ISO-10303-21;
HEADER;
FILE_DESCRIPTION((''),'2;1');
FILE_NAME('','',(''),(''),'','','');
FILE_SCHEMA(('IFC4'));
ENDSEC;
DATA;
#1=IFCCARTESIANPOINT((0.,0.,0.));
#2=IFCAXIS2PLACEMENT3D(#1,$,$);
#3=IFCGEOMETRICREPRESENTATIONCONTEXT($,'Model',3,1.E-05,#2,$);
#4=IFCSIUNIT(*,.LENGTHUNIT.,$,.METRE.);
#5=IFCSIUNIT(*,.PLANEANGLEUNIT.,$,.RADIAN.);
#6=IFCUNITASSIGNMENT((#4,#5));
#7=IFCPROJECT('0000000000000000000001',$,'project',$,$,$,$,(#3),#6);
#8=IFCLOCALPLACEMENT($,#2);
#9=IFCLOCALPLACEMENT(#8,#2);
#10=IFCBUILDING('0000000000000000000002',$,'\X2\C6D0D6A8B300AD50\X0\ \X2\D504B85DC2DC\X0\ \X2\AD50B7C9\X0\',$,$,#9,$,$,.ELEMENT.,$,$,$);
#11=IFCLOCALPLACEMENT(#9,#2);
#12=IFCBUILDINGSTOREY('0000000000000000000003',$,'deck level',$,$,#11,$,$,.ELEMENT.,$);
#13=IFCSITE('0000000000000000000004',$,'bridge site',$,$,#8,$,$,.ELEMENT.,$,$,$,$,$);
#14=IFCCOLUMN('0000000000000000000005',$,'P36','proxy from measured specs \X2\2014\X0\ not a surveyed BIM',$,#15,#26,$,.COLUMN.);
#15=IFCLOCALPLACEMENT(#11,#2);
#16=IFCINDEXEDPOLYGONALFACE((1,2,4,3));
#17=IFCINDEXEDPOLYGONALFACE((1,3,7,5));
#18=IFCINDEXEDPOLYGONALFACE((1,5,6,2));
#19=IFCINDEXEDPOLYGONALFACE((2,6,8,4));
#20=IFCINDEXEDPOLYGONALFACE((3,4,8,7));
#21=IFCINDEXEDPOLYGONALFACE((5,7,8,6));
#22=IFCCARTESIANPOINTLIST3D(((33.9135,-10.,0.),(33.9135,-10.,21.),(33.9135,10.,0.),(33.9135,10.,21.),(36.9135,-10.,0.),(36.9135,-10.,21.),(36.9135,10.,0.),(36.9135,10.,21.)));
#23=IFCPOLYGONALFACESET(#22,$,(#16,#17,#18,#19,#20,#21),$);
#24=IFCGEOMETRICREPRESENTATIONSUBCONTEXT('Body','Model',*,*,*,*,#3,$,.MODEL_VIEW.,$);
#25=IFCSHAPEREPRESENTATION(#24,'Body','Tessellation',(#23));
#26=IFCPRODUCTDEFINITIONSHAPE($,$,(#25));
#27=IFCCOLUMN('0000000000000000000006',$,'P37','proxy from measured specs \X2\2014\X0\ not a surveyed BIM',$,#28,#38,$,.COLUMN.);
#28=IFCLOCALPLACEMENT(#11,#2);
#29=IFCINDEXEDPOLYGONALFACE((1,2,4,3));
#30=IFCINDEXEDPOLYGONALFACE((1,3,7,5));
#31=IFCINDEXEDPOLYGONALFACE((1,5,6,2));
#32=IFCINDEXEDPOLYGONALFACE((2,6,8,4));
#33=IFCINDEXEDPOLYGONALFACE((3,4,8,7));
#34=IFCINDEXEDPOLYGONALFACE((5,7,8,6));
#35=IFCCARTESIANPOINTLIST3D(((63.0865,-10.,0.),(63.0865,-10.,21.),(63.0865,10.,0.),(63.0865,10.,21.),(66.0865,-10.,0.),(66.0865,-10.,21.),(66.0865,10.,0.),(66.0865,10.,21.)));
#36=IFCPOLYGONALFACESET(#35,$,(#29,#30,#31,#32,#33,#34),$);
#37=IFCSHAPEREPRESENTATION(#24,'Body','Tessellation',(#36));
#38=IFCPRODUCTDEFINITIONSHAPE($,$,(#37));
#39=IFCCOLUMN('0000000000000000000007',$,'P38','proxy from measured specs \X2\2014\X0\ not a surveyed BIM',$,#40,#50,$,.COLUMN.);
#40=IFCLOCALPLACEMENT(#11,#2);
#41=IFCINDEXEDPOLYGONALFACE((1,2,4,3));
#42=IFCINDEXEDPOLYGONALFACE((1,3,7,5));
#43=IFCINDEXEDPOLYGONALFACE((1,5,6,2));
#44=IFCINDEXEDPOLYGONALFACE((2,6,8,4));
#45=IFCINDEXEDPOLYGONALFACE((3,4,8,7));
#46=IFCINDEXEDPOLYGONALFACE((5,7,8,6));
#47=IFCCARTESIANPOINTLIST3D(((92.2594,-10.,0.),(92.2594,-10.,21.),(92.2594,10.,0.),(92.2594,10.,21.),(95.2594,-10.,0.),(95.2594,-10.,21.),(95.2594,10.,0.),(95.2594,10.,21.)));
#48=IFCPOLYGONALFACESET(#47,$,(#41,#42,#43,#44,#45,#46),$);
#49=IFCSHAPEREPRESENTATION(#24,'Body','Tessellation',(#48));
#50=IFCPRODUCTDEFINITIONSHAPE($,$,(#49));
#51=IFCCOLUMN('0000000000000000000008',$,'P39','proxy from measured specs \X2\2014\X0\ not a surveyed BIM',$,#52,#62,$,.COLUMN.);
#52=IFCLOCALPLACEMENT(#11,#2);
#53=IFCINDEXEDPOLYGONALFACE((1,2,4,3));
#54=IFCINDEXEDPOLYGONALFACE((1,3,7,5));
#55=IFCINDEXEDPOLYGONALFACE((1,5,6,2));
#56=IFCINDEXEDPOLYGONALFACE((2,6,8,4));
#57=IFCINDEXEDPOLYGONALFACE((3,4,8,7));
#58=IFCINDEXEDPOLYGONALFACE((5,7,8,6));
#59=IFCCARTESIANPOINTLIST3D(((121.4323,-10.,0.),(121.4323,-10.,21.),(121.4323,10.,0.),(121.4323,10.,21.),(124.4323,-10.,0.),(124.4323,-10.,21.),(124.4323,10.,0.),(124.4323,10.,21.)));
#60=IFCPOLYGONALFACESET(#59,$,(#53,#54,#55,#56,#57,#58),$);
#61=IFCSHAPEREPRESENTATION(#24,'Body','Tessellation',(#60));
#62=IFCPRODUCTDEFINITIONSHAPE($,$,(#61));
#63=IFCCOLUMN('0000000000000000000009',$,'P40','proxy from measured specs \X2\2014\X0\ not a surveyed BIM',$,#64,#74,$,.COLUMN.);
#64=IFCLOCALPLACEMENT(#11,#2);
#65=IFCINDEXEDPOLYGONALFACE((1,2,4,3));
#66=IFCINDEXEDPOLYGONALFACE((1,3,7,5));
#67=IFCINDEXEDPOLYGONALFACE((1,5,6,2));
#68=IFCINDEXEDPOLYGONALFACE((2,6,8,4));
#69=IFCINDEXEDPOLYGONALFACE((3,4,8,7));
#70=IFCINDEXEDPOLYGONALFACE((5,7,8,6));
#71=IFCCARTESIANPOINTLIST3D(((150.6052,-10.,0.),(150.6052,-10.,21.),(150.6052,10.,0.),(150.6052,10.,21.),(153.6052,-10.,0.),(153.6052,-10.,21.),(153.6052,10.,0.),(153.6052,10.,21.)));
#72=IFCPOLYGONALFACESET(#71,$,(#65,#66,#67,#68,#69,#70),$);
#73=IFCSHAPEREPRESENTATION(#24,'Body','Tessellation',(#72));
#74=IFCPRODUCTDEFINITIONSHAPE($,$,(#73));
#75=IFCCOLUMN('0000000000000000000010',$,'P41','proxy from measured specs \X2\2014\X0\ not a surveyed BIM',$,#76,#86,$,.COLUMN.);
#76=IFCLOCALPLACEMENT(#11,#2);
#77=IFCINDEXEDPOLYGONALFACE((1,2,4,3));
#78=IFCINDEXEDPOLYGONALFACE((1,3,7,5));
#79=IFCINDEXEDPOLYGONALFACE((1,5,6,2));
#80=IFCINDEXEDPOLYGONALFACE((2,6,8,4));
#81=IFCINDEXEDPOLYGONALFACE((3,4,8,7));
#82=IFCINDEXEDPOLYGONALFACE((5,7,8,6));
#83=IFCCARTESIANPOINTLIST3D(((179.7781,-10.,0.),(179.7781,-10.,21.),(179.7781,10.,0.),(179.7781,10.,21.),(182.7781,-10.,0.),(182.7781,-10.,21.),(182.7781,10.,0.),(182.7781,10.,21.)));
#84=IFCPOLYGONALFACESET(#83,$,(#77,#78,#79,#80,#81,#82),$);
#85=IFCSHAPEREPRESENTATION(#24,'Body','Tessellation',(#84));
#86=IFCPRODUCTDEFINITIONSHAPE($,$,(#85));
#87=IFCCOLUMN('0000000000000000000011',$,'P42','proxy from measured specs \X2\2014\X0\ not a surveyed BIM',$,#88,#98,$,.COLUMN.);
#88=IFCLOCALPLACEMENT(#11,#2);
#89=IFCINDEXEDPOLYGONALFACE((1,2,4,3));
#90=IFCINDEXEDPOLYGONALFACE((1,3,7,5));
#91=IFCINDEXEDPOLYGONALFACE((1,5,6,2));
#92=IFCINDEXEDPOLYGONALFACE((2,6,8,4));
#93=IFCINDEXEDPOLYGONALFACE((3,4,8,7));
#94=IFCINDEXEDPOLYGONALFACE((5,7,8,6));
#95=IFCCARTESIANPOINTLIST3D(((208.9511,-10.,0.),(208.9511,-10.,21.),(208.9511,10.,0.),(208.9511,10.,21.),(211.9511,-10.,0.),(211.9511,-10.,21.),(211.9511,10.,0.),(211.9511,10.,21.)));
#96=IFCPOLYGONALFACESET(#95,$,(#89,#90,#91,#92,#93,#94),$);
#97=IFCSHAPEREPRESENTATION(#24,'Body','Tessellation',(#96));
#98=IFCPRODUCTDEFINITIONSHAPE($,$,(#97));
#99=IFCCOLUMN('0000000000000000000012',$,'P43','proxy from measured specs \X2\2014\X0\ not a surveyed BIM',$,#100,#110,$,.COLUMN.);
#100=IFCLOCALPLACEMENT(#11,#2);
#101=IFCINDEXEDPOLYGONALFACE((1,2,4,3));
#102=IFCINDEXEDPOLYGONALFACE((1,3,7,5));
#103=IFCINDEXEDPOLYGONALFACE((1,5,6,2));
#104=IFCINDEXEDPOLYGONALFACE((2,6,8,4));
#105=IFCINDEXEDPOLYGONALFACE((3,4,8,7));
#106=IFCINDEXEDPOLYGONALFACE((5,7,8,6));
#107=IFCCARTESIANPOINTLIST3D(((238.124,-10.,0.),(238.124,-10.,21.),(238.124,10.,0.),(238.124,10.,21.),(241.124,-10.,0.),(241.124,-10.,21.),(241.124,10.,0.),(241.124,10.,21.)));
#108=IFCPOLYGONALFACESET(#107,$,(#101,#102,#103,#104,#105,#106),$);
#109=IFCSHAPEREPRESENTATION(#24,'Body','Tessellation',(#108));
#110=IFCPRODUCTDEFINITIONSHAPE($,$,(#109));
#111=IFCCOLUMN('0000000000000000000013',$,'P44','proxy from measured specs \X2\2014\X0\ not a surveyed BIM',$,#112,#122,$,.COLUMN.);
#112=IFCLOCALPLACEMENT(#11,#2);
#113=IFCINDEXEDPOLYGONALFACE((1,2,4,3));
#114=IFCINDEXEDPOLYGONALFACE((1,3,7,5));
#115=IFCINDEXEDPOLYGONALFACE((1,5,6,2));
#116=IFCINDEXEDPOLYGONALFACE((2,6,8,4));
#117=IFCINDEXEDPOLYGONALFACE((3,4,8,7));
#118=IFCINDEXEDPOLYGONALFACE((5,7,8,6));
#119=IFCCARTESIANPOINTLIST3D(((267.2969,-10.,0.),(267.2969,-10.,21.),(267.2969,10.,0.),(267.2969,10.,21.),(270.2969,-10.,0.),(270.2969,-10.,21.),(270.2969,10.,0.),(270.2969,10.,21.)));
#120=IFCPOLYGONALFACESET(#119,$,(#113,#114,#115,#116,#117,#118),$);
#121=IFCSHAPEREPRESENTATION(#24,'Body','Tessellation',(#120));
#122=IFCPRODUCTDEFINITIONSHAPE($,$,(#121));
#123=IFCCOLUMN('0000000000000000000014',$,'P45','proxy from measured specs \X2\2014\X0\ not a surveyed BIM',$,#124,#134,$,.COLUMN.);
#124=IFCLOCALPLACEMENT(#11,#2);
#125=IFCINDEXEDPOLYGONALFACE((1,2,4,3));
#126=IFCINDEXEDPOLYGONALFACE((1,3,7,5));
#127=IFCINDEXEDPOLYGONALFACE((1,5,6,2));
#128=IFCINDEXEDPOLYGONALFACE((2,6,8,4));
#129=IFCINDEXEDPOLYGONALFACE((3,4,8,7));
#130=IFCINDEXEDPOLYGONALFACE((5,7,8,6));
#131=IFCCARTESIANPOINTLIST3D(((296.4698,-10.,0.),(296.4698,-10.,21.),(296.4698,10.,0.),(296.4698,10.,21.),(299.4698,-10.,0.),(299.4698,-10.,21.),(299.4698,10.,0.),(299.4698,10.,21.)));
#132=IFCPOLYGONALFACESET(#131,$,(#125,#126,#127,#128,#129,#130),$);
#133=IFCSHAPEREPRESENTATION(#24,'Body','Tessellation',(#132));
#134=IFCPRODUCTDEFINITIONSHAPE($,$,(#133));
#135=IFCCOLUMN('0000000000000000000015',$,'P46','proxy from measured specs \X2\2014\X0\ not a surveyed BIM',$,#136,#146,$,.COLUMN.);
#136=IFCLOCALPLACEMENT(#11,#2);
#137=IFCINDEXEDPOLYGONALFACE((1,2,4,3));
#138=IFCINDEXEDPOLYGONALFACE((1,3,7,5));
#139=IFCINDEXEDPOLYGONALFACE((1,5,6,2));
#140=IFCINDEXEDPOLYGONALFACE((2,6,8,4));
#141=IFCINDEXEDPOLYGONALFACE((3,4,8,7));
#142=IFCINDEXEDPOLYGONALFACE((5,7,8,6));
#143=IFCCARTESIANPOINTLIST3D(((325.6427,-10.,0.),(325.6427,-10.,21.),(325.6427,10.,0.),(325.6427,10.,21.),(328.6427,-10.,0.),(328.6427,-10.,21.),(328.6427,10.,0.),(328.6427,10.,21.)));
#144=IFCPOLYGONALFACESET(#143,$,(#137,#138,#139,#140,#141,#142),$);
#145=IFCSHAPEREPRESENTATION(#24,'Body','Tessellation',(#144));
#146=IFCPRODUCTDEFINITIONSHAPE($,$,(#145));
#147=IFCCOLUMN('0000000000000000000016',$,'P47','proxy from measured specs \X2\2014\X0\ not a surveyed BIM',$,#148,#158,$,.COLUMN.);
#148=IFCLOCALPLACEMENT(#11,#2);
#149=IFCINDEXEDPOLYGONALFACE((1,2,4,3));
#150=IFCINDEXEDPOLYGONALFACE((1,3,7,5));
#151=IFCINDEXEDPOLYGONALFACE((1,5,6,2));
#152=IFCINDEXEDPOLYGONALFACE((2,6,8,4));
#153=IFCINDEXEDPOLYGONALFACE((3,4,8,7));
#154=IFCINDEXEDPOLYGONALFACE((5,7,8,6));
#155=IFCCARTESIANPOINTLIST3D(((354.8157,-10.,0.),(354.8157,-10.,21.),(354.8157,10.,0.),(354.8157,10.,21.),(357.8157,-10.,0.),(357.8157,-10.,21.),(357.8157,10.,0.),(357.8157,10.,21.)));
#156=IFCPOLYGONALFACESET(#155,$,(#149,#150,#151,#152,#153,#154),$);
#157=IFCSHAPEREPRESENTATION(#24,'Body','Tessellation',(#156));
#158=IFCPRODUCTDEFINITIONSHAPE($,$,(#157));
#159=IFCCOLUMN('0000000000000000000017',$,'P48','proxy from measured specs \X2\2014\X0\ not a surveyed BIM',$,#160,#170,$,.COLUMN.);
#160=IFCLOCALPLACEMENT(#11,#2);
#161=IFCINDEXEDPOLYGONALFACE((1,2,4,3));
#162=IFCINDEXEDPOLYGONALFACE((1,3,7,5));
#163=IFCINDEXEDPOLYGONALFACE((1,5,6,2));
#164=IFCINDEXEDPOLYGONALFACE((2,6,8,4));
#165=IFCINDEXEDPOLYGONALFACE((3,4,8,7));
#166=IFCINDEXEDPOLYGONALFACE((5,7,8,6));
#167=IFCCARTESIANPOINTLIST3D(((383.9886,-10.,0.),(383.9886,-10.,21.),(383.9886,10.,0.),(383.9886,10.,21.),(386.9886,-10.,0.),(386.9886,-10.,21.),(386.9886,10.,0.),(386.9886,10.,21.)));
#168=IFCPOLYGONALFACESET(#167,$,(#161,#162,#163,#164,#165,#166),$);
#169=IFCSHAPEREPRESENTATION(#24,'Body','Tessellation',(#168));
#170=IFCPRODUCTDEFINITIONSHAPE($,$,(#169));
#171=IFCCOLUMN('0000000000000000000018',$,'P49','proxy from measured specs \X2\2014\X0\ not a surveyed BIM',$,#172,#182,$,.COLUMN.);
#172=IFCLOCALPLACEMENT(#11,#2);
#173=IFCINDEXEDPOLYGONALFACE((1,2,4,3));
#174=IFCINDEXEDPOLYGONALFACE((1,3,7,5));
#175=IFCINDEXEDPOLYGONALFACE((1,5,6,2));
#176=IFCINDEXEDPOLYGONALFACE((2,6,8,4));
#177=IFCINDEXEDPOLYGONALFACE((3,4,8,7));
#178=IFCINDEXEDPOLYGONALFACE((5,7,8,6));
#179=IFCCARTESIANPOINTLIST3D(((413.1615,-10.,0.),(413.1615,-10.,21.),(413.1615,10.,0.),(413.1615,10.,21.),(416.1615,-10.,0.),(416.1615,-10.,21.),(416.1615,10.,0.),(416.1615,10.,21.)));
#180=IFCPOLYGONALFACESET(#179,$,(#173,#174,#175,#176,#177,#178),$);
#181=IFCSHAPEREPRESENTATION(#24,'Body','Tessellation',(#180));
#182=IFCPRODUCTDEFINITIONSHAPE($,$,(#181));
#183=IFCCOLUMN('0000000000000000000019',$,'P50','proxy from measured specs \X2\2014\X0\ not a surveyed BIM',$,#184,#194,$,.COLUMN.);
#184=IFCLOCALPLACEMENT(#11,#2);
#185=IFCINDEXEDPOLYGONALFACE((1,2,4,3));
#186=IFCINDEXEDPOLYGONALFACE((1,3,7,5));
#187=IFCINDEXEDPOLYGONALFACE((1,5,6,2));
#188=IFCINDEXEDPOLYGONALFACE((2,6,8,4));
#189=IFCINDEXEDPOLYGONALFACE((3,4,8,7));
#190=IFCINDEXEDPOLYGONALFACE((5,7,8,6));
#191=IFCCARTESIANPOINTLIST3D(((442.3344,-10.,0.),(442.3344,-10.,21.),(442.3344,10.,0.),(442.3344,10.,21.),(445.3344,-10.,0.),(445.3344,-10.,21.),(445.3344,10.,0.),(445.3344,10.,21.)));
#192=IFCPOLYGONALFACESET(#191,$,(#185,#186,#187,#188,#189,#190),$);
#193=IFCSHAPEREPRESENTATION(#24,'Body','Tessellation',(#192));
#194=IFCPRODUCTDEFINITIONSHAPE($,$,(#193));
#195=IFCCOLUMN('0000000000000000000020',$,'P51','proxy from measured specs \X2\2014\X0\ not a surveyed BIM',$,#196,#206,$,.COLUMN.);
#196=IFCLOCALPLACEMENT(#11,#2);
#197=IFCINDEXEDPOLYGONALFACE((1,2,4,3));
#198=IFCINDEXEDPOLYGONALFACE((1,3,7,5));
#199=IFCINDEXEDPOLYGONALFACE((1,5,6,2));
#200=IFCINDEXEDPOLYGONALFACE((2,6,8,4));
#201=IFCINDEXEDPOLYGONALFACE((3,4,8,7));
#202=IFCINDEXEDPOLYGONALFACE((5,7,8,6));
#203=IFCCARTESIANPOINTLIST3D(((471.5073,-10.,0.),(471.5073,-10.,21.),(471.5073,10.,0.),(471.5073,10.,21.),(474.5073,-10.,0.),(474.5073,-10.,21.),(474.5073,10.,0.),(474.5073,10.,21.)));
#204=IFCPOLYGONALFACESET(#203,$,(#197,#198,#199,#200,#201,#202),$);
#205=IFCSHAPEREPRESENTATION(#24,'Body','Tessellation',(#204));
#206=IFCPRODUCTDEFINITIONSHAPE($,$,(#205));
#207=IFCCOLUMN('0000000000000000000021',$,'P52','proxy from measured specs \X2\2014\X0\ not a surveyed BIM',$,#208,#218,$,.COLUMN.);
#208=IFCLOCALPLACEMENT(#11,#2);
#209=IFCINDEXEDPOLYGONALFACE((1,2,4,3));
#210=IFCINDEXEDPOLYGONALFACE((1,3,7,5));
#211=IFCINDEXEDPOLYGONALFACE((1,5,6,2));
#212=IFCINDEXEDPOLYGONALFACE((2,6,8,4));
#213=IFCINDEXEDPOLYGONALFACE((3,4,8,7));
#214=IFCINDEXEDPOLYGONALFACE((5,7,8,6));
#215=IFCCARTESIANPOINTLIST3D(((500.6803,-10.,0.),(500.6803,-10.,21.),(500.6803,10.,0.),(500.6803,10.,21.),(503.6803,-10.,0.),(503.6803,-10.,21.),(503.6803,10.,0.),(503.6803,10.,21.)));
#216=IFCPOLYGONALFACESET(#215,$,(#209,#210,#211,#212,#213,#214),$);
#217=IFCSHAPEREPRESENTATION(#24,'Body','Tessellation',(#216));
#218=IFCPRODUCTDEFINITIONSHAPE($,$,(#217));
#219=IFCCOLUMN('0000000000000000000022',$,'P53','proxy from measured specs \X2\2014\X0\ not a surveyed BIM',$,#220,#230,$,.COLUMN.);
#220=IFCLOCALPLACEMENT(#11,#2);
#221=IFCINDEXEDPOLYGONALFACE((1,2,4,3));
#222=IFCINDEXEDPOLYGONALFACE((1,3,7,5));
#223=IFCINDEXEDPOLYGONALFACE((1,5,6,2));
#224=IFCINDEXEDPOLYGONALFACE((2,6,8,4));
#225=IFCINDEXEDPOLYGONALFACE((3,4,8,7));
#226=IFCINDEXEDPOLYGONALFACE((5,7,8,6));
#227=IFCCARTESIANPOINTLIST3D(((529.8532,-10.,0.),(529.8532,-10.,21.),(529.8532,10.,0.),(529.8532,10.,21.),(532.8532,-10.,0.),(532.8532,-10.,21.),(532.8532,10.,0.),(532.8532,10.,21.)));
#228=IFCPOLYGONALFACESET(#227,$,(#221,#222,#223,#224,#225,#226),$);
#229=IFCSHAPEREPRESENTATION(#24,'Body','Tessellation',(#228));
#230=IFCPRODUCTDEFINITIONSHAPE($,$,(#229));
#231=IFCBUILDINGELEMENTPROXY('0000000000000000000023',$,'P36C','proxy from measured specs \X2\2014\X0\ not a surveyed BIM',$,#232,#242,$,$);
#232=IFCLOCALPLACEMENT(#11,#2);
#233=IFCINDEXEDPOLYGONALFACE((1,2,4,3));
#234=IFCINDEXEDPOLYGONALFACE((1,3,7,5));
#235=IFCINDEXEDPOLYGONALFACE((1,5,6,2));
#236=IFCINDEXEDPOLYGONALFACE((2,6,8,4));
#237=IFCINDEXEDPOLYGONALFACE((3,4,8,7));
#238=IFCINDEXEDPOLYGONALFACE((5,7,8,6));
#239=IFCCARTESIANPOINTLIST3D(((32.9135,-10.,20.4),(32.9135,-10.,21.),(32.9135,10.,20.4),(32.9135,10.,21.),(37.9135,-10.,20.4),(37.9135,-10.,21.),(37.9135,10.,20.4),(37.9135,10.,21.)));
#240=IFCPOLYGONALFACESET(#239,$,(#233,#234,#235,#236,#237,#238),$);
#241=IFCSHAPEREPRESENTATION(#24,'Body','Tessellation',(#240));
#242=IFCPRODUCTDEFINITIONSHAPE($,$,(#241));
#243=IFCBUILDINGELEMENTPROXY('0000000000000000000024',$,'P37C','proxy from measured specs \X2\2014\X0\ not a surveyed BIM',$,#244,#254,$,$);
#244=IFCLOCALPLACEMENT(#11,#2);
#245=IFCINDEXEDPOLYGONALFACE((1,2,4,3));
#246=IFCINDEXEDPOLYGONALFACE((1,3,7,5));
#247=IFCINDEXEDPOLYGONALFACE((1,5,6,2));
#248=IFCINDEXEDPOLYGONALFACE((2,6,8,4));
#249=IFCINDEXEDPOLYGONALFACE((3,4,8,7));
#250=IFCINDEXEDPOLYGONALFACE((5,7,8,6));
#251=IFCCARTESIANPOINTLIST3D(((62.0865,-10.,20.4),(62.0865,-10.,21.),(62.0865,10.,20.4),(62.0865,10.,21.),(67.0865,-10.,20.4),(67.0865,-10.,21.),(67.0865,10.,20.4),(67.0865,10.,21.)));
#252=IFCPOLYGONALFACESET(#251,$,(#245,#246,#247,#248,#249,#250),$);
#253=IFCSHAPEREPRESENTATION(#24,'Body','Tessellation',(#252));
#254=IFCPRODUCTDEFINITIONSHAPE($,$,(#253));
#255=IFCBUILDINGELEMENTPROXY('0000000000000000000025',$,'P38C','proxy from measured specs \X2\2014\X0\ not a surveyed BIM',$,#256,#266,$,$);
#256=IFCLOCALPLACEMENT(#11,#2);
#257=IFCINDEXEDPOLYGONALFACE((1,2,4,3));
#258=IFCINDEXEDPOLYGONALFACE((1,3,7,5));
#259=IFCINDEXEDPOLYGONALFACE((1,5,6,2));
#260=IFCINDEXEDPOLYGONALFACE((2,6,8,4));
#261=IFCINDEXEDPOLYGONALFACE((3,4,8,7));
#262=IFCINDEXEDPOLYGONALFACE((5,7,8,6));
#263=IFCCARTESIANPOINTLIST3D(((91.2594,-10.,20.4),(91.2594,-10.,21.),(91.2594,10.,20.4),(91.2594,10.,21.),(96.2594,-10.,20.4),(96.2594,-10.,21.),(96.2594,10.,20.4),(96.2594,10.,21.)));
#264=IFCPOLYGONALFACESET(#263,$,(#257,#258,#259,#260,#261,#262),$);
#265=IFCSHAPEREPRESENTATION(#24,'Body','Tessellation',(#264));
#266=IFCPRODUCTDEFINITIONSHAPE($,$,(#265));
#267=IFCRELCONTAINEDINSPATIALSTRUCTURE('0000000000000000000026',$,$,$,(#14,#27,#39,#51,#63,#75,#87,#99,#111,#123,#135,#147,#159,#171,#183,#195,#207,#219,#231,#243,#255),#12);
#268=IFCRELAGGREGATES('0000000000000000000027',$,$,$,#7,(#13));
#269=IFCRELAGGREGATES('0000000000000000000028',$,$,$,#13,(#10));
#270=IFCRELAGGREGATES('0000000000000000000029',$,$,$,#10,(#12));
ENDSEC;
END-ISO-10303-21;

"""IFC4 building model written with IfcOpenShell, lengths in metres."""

from ifc_helpers import new_model, si_unit, frame, origin, origin_2d, place, context, subcontext, project, spatial, rectangle, extrude, element, save


model = new_model("IFC4")

# Units and contexts
model_context = context("Model", 3, precision=1e-05, world=origin())
body_context = subcontext(model_context, "Body", "Model", "MODEL_VIEW")
ifc_project = project(units=[si_unit("LENGTHUNIT", "METRE"), si_unit("PLANEANGLEUNIT", "RADIAN")], contexts=[model_context])

# Site, building, storey
site_placement = place(None, origin())
site = spatial("IfcSite", under=ifc_project, at=site_placement, Name="bridge site", CompositionType="ELEMENT")
building_placement = place(site_placement, origin())
building = spatial("IfcBuilding", under=site, at=building_placement, Name="원효대교 프록시 교량", CompositionType="ELEMENT")
storey_placement = place(building_placement, origin())
storey = spatial("IfcBuildingStorey", under=building, at=storey_placement, Name="deck level", CompositionType="ELEMENT")

# Columns
for number, where, name in (
    (1, (35.4135, 0.0, 0.0), "P36"),
    (2, (64.5865, 0.0, 0.0), "P37"),
    (3, (93.7594, 0.0, 0.0), "P38"),
    (4, (122.9323, 0.0, 0.0), "P39"),
    (5, (152.1052, 0.0, 0.0), "P40"),
    (6, (181.2781, 0.0, 0.0), "P41"),
    (7, (210.4511, 0.0, 0.0), "P42"),
    (8, (239.624, 0.0, 0.0), "P43"),
    (9, (268.7969, 0.0, 0.0), "P44"),
    (10, (297.9698, 0.0, 0.0), "P45"),
    (11, (327.1427, 0.0, 0.0), "P46"),
    (12, (356.3157, 0.0, 0.0), "P47"),
    (13, (385.4886, 0.0, 0.0), "P48"),
    (14, (414.6615, 0.0, 0.0), "P49"),
    (15, (443.8344, 0.0, 0.0), "P50"),
    (16, (473.0073, 0.0, 0.0), "P51"),
    (17, (502.1803, 0.0, 0.0), "P52"),
    (18, (531.3532, 0.0, 0.0), "P53"),
):
    element("IfcColumn", number, at=place(storey_placement, frame(where)), inside=storey, Name=name, Description="proxy from measured specs — not a surveyed BIM", PredefinedType="COLUMN", context=body_context, shape_type="SweptSolid", body=[
        extrude(rectangle(XDim=3.0, YDim=20.0, at=origin_2d()), origin(), (0.0, 0.0, 1.0), 21.0),
    ])

# Building element proxies
for number, where, name in (
    (19, (35.4135, 0.0, 20.4), "P36C"),
    (20, (64.5865, 0.0, 20.4), "P37C"),
    (21, (93.7594, 0.0, 20.4), "P38C"),
):
    element("IfcBuildingElementProxy", number, at=place(storey_placement, frame(where)), inside=storey, Name=name, Description="proxy from measured specs — not a surveyed BIM", context=body_context, shape_type="SweptSolid", body=[
        extrude(rectangle(XDim=5.0, YDim=20.0, at=origin_2d()), origin(), (0.0, 0.0, 1.0), 0.6),
    ])

save(model, "model.ifc")
